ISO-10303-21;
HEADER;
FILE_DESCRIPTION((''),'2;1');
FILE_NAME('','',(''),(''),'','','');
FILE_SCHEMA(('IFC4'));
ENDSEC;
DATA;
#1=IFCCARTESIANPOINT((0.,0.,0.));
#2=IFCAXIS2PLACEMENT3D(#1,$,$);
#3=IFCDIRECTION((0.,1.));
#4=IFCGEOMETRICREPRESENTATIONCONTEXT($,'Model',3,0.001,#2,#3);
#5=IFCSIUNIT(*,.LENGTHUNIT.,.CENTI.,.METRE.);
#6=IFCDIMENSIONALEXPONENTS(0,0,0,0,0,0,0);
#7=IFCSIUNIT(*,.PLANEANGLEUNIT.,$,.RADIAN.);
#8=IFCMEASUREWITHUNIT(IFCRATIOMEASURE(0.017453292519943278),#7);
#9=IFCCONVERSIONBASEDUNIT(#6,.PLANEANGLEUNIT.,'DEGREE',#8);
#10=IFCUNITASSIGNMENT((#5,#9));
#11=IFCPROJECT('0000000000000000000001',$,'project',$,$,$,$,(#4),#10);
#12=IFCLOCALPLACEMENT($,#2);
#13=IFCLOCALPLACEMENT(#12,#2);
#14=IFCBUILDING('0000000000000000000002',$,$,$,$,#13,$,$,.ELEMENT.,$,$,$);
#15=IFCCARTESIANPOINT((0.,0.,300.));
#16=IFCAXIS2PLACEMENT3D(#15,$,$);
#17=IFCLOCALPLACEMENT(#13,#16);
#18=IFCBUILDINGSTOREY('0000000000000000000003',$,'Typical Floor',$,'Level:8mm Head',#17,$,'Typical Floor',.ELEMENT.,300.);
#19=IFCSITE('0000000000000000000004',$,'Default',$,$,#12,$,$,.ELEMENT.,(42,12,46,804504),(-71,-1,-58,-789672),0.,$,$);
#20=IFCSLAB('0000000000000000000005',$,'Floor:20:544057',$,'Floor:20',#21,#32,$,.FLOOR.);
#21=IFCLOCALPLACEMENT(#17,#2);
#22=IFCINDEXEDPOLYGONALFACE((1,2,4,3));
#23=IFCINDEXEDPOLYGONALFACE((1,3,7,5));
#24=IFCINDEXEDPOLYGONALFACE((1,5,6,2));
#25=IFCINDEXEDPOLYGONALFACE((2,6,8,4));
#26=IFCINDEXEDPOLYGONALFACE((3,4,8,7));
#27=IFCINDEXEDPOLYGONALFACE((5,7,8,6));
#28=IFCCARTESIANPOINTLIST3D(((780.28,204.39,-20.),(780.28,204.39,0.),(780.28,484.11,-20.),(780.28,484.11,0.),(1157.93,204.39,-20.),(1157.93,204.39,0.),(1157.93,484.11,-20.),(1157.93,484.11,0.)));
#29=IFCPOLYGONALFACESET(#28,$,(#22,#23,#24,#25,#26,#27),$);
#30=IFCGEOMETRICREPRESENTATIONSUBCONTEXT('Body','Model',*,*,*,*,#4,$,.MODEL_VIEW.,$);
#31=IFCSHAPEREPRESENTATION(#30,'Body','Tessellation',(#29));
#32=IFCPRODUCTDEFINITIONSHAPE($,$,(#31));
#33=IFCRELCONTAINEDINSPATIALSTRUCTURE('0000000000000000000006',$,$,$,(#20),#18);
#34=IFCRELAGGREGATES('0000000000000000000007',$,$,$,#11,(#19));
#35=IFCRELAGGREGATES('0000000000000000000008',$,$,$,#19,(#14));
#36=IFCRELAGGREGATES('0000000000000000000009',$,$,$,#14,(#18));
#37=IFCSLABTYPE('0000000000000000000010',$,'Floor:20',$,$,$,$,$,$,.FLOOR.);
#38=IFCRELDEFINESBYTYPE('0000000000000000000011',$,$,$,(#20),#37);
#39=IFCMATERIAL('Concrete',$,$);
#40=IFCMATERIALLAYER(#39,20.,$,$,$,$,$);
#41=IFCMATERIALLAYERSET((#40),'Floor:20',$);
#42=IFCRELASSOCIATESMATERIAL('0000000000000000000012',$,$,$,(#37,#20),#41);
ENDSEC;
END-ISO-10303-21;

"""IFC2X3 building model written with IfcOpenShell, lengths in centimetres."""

from ifc_helpers import new_model, entity, si_unit, converted_unit, direction, frame, frame_2d, origin, place, context, subcontext, project, spatial, rectangle, extrude, material, layer, layer_set, layer_usage, type_object, element, save


model = new_model("IFC2X3")

# Units and contexts
model_context = context("Model", 3, precision=0.001, world=origin(), true_north=direction((0.0, 1.0)))
body_context = subcontext(model_context, "Body", "Model", "MODEL_VIEW")
ifc_project = project(units=[si_unit("LENGTHUNIT", "METRE", prefix="CENTI"), converted_unit("PLANEANGLEUNIT", "DEGREE", entity("IfcRatioMeasure", 0.017453292519943278), si_unit("PLANEANGLEUNIT", "RADIAN"), dimensions=[0, 0, 0, 0, 0, 0, 0])], contexts=[model_context])

# Site, building, storey
site_placement = place(None, origin())
site = spatial("IfcSite", under=ifc_project, at=site_placement, Name="Default", CompositionType="ELEMENT", RefLatitude=(42, 12, 46, 804504), RefLongitude=(-71, -1, -58, -789672), RefElevation=0.0)
building_placement = place(site_placement, origin())
building = spatial("IfcBuilding", under=site, at=building_placement, CompositionType="ELEMENT")
storey_placement = place(building_placement, frame((0.0, 0.0, 300.0)))
storey = spatial("IfcBuildingStorey", under=building, at=storey_placement, Name="Typical Floor", ObjectType="Level:8mm Head", LongName="Typical Floor", CompositionType="ELEMENT", Elevation=300.0)

# Shared definitions
ifc_material_1 = material(Name="Concrete")

# Slab
ifc_layer_1 = layer(ifc_material_1, 20.0)
ifc_layer_set_1 = layer_set([ifc_layer_1], Name="Floor:20")
ifc_layer_usage_1 = layer_usage(ifc_layer_set_1, "AXIS3", "POSITIVE", 0.0)
slab_type_1 = type_object("IfcSlabType", Name="Floor:20", PredefinedType="FLOOR", material=ifc_layer_set_1)
slab_1_placement = place(storey_placement, origin())
element("IfcSlab", 1, at=slab_1_placement, inside=storey, type_object=slab_type_1, material=ifc_layer_usage_1, Name="Floor:20:544057", ObjectType="Floor:20", PredefinedType="FLOOR", context=body_context, shape_type="SweptSolid", body=[
    extrude(rectangle(XDim=279.72, YDim=377.65, at=frame_2d((0.0, 0.0), x_axis=(1.0, 0.0))), frame((969.11, 344.25, 0.0), z_axis=(0.0, 0.0, -1.0), x_axis=(0.0, 1.0, 0.0)), (0.0, 0.0, 1.0), 20.0),
])

save(model, "model.ifc")
